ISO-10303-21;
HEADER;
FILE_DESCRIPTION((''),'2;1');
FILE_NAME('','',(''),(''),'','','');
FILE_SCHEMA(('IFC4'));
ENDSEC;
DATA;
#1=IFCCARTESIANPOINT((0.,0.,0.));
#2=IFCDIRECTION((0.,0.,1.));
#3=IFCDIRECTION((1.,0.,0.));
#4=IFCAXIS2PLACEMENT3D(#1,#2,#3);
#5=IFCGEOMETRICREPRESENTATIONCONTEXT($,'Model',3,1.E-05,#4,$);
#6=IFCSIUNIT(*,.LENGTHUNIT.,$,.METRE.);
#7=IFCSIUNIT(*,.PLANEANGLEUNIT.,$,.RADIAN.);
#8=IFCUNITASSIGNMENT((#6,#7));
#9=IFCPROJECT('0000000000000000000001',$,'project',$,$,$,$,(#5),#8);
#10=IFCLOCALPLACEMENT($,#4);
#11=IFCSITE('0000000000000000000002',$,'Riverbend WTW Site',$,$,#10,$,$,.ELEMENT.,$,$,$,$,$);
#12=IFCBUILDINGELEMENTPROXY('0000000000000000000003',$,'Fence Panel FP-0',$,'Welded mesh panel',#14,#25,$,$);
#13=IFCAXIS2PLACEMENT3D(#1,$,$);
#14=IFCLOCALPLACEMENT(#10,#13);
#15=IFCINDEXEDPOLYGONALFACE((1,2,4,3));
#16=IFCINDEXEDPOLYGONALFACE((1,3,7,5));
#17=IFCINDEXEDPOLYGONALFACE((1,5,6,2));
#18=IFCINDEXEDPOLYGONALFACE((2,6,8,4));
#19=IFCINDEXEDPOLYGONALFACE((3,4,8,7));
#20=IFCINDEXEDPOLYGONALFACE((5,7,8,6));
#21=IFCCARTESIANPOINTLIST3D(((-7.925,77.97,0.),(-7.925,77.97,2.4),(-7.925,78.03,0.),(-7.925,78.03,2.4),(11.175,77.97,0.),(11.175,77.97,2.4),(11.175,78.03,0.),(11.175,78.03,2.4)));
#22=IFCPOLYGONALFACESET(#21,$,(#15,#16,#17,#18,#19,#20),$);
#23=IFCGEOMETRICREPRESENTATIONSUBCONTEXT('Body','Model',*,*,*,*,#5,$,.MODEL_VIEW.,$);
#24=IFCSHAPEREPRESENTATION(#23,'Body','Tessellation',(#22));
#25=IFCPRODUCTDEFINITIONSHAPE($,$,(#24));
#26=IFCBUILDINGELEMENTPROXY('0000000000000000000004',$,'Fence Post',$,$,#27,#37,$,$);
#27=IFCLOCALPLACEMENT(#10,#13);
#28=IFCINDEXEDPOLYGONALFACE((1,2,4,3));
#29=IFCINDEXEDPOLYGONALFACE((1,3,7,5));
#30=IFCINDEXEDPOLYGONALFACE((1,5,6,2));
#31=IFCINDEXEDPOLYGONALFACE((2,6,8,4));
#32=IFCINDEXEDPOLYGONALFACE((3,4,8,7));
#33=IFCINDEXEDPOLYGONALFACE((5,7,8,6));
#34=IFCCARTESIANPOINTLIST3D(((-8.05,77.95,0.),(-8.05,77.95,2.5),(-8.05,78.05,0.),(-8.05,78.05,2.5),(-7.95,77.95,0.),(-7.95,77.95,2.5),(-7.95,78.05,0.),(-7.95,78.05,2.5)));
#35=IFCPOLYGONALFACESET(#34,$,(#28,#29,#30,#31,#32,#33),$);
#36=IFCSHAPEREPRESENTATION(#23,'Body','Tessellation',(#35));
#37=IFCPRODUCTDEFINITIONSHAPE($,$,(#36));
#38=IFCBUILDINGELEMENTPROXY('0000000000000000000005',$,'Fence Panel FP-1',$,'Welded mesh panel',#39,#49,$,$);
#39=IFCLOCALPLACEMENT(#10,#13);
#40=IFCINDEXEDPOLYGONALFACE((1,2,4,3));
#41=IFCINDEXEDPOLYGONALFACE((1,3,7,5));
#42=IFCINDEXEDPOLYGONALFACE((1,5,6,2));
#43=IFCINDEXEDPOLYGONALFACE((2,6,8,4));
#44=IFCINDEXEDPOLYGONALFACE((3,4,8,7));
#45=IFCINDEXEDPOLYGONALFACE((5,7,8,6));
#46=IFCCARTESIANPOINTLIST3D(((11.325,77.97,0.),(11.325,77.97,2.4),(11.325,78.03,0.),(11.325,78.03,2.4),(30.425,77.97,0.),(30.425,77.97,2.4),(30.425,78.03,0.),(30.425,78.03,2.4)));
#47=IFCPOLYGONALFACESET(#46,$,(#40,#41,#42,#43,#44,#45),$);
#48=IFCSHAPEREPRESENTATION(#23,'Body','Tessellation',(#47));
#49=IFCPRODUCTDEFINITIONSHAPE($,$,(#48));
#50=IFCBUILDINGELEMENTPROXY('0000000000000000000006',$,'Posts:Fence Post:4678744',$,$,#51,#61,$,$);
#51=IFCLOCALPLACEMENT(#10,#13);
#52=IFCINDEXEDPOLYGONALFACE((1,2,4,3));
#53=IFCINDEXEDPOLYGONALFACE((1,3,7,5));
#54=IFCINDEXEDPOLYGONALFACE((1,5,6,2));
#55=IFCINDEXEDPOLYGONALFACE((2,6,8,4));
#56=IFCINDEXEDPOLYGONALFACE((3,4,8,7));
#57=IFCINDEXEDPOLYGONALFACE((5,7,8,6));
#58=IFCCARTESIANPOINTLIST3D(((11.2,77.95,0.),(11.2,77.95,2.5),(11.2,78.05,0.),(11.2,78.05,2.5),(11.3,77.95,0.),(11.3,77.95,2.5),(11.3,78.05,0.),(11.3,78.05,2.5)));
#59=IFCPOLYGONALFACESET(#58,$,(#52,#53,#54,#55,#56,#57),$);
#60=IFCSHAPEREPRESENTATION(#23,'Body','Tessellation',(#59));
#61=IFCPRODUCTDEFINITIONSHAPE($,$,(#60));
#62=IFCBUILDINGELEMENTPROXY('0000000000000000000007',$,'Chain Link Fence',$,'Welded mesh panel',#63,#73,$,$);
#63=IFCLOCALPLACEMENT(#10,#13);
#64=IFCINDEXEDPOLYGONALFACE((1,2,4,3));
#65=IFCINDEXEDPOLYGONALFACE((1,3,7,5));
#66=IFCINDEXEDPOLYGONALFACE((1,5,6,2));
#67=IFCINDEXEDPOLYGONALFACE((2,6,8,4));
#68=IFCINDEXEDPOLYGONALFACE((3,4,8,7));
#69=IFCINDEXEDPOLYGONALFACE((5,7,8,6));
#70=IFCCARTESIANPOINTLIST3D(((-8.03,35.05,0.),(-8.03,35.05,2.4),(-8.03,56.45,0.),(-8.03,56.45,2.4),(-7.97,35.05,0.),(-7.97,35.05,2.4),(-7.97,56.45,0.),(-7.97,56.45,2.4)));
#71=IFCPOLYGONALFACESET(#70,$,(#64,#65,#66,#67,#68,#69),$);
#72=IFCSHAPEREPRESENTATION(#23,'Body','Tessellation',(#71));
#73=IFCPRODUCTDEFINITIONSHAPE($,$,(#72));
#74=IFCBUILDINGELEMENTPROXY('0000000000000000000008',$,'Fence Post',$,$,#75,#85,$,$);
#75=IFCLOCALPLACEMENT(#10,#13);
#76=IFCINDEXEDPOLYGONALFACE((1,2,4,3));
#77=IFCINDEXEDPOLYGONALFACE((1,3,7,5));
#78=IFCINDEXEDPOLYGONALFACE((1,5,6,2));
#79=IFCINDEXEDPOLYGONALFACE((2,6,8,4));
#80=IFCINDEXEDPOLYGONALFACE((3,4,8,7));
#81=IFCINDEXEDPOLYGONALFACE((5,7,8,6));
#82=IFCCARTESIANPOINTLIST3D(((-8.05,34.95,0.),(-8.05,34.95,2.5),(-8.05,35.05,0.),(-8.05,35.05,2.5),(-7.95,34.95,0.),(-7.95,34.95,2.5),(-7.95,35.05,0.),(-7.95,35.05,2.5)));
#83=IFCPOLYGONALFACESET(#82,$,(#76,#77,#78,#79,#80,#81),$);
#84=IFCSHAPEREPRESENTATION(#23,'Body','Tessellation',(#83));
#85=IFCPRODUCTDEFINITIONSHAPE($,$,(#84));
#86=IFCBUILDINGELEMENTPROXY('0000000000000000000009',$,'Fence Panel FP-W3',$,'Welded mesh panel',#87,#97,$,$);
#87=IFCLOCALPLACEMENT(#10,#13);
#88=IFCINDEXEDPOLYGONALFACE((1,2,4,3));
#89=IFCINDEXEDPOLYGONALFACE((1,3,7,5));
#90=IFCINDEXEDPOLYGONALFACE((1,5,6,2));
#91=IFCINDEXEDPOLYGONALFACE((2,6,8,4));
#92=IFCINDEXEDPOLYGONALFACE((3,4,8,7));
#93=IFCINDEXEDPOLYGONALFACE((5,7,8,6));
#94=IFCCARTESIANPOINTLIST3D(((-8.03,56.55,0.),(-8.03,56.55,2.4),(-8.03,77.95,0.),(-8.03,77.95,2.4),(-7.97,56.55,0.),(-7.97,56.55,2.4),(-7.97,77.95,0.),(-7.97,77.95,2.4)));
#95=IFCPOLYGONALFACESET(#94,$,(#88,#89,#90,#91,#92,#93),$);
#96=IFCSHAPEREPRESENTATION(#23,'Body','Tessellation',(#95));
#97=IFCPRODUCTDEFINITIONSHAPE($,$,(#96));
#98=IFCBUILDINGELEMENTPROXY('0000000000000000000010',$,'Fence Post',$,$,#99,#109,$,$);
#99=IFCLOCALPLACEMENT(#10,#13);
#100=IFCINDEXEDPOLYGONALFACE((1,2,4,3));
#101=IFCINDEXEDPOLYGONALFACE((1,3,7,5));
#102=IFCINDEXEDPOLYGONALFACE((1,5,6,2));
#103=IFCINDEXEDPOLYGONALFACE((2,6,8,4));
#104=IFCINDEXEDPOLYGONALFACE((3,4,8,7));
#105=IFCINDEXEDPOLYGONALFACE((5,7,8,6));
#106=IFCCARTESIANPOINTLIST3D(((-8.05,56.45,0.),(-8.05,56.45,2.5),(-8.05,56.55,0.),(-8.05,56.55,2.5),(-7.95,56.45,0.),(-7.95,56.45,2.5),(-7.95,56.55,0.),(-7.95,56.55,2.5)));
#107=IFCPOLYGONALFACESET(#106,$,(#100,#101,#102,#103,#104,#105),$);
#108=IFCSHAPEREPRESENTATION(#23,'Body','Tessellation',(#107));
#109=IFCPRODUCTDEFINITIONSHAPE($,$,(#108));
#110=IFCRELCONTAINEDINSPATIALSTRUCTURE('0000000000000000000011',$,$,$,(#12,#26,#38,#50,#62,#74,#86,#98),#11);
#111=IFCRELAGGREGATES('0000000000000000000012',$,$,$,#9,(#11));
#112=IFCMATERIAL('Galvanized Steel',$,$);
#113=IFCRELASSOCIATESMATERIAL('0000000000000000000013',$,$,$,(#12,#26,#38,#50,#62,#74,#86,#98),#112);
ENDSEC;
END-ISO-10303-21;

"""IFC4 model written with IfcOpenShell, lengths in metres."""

from ifc_helpers import new_model, si_unit, frame, origin_with_axes, origin_2d, place, context, subcontext, project, spatial, rectangle, extrude, material, element, save


model = new_model("IFC4")

# Units and contexts
model_context = context("Model", 3, precision=1e-05, world=origin_with_axes())
body_context = subcontext(model_context, "Body", "Model", "MODEL_VIEW")
ifc_project = project(units=[si_unit("LENGTHUNIT", "METRE"), si_unit("PLANEANGLEUNIT", "RADIAN")], contexts=[model_context])

# Site
site_placement = place(None, origin_with_axes())
site = spatial("IfcSite", under=ifc_project, at=site_placement, Name="Riverbend WTW Site", CompositionType="ELEMENT")

# Shared definitions
ifc_material_1 = material(Name="Galvanized Steel")

# Building element proxies
proxy_1_placement = place(None, frame((1.625, 78.0, 1.2), z_axis=(0.0, 0.0, 1.0), x_axis=(1.0, 0.0, 0.0)))
element("IfcBuildingElementProxy", 1, at=proxy_1_placement, inside=site, material=ifc_material_1, Name="Fence Panel FP-0", ObjectType="Welded mesh panel", context=body_context, shape_type="SweptSolid", body=[
    extrude(rectangle(XDim=19.1, YDim=0.06, at=origin_2d()), frame((0.0, 0.0, -1.2), z_axis=(0.0, 0.0, 1.0), x_axis=(1.0, 0.0, 0.0)), (0.0, 0.0, 1.0), 2.4),
])
proxy_2_placement = place(None, frame((-8.0, 78.0, 1.25), z_axis=(0.0, 0.0, 1.0), x_axis=(1.0, 0.0, 0.0)))
element("IfcBuildingElementProxy", 2, at=proxy_2_placement, inside=site, material=ifc_material_1, Name="Fence Post", context=body_context, shape_type="SweptSolid", body=[
    extrude(rectangle(XDim=0.1, YDim=0.1, at=origin_2d()), frame((0.0, 0.0, -1.25), z_axis=(0.0, 0.0, 1.0), x_axis=(1.0, 0.0, 0.0)), (0.0, 0.0, 1.0), 2.5),
])
proxy_3_placement = place(None, frame((20.875, 78.0, 1.2), z_axis=(0.0, 0.0, 1.0), x_axis=(1.0, 0.0, 0.0)))
element("IfcBuildingElementProxy", 3, at=proxy_3_placement, inside=site, material=ifc_material_1, Name="Fence Panel FP-1", ObjectType="Welded mesh panel", context=body_context, shape_type="SweptSolid", body=[
    extrude(rectangle(XDim=19.1, YDim=0.06, at=origin_2d()), frame((0.0, 0.0, -1.2), z_axis=(0.0, 0.0, 1.0), x_axis=(1.0, 0.0, 0.0)), (0.0, 0.0, 1.0), 2.4),
])
proxy_4_placement = place(None, frame((11.25, 78.0, 1.25), z_axis=(0.0, 0.0, 1.0), x_axis=(1.0, 0.0, 0.0)))
element("IfcBuildingElementProxy", 4, at=proxy_4_placement, inside=site, material=ifc_material_1, Name="Posts:Fence Post:4678744", context=body_context, shape_type="SweptSolid", body=[
    extrude(rectangle(XDim=0.1, YDim=0.1, at=origin_2d()), frame((0.0, 0.0, -1.25), z_axis=(0.0, 0.0, 1.0), x_axis=(1.0, 0.0, 0.0)), (0.0, 0.0, 1.0), 2.5),
])
proxy_5_placement = place(None, frame((-8.0, 45.75, 1.2), z_axis=(0.0, 0.0, 1.0), x_axis=(1.0, 0.0, 0.0)))
element("IfcBuildingElementProxy", 5, at=proxy_5_placement, inside=site, material=ifc_material_1, Name="Chain Link Fence", ObjectType="Welded mesh panel", context=body_context, shape_type="SweptSolid", body=[
    extrude(rectangle(XDim=0.06, YDim=21.4, at=origin_2d()), frame((0.0, 0.0, -1.2), z_axis=(0.0, 0.0, 1.0), x_axis=(1.0, 0.0, 0.0)), (0.0, 0.0, 1.0), 2.4),
])
proxy_6_placement = place(None, frame((-8.0, 35.0, 1.25), z_axis=(0.0, 0.0, 1.0), x_axis=(1.0, 0.0, 0.0)))
element("IfcBuildingElementProxy", 6, at=proxy_6_placement, inside=site, material=ifc_material_1, Name="Fence Post", context=body_context, shape_type="SweptSolid", body=[
    extrude(rectangle(XDim=0.1, YDim=0.1, at=origin_2d()), frame((0.0, 0.0, -1.25), z_axis=(0.0, 0.0, 1.0), x_axis=(1.0, 0.0, 0.0)), (0.0, 0.0, 1.0), 2.5),
])
proxy_7_placement = place(None, frame((-8.0, 67.25, 1.2), z_axis=(0.0, 0.0, 1.0), x_axis=(1.0, 0.0, 0.0)))
element("IfcBuildingElementProxy", 7, at=proxy_7_placement, inside=site, material=ifc_material_1, Name="Fence Panel FP-W3", ObjectType="Welded mesh panel", context=body_context, shape_type="SweptSolid", body=[
    extrude(rectangle(XDim=0.06, YDim=21.4, at=origin_2d()), frame((0.0, 0.0, -1.2), z_axis=(0.0, 0.0, 1.0), x_axis=(1.0, 0.0, 0.0)), (0.0, 0.0, 1.0), 2.4),
])
proxy_8_placement = place(None, frame((-8.0, 56.5, 1.25), z_axis=(0.0, 0.0, 1.0), x_axis=(1.0, 0.0, 0.0)))
element("IfcBuildingElementProxy", 8, at=proxy_8_placement, inside=site, material=ifc_material_1, Name="Fence Post", context=body_context, shape_type="SweptSolid", body=[
    extrude(rectangle(XDim=0.1, YDim=0.1, at=origin_2d()), frame((0.0, 0.0, -1.25), z_axis=(0.0, 0.0, 1.0), x_axis=(1.0, 0.0, 0.0)), (0.0, 0.0, 1.0), 2.5),
])

save(model, "model.ifc")
